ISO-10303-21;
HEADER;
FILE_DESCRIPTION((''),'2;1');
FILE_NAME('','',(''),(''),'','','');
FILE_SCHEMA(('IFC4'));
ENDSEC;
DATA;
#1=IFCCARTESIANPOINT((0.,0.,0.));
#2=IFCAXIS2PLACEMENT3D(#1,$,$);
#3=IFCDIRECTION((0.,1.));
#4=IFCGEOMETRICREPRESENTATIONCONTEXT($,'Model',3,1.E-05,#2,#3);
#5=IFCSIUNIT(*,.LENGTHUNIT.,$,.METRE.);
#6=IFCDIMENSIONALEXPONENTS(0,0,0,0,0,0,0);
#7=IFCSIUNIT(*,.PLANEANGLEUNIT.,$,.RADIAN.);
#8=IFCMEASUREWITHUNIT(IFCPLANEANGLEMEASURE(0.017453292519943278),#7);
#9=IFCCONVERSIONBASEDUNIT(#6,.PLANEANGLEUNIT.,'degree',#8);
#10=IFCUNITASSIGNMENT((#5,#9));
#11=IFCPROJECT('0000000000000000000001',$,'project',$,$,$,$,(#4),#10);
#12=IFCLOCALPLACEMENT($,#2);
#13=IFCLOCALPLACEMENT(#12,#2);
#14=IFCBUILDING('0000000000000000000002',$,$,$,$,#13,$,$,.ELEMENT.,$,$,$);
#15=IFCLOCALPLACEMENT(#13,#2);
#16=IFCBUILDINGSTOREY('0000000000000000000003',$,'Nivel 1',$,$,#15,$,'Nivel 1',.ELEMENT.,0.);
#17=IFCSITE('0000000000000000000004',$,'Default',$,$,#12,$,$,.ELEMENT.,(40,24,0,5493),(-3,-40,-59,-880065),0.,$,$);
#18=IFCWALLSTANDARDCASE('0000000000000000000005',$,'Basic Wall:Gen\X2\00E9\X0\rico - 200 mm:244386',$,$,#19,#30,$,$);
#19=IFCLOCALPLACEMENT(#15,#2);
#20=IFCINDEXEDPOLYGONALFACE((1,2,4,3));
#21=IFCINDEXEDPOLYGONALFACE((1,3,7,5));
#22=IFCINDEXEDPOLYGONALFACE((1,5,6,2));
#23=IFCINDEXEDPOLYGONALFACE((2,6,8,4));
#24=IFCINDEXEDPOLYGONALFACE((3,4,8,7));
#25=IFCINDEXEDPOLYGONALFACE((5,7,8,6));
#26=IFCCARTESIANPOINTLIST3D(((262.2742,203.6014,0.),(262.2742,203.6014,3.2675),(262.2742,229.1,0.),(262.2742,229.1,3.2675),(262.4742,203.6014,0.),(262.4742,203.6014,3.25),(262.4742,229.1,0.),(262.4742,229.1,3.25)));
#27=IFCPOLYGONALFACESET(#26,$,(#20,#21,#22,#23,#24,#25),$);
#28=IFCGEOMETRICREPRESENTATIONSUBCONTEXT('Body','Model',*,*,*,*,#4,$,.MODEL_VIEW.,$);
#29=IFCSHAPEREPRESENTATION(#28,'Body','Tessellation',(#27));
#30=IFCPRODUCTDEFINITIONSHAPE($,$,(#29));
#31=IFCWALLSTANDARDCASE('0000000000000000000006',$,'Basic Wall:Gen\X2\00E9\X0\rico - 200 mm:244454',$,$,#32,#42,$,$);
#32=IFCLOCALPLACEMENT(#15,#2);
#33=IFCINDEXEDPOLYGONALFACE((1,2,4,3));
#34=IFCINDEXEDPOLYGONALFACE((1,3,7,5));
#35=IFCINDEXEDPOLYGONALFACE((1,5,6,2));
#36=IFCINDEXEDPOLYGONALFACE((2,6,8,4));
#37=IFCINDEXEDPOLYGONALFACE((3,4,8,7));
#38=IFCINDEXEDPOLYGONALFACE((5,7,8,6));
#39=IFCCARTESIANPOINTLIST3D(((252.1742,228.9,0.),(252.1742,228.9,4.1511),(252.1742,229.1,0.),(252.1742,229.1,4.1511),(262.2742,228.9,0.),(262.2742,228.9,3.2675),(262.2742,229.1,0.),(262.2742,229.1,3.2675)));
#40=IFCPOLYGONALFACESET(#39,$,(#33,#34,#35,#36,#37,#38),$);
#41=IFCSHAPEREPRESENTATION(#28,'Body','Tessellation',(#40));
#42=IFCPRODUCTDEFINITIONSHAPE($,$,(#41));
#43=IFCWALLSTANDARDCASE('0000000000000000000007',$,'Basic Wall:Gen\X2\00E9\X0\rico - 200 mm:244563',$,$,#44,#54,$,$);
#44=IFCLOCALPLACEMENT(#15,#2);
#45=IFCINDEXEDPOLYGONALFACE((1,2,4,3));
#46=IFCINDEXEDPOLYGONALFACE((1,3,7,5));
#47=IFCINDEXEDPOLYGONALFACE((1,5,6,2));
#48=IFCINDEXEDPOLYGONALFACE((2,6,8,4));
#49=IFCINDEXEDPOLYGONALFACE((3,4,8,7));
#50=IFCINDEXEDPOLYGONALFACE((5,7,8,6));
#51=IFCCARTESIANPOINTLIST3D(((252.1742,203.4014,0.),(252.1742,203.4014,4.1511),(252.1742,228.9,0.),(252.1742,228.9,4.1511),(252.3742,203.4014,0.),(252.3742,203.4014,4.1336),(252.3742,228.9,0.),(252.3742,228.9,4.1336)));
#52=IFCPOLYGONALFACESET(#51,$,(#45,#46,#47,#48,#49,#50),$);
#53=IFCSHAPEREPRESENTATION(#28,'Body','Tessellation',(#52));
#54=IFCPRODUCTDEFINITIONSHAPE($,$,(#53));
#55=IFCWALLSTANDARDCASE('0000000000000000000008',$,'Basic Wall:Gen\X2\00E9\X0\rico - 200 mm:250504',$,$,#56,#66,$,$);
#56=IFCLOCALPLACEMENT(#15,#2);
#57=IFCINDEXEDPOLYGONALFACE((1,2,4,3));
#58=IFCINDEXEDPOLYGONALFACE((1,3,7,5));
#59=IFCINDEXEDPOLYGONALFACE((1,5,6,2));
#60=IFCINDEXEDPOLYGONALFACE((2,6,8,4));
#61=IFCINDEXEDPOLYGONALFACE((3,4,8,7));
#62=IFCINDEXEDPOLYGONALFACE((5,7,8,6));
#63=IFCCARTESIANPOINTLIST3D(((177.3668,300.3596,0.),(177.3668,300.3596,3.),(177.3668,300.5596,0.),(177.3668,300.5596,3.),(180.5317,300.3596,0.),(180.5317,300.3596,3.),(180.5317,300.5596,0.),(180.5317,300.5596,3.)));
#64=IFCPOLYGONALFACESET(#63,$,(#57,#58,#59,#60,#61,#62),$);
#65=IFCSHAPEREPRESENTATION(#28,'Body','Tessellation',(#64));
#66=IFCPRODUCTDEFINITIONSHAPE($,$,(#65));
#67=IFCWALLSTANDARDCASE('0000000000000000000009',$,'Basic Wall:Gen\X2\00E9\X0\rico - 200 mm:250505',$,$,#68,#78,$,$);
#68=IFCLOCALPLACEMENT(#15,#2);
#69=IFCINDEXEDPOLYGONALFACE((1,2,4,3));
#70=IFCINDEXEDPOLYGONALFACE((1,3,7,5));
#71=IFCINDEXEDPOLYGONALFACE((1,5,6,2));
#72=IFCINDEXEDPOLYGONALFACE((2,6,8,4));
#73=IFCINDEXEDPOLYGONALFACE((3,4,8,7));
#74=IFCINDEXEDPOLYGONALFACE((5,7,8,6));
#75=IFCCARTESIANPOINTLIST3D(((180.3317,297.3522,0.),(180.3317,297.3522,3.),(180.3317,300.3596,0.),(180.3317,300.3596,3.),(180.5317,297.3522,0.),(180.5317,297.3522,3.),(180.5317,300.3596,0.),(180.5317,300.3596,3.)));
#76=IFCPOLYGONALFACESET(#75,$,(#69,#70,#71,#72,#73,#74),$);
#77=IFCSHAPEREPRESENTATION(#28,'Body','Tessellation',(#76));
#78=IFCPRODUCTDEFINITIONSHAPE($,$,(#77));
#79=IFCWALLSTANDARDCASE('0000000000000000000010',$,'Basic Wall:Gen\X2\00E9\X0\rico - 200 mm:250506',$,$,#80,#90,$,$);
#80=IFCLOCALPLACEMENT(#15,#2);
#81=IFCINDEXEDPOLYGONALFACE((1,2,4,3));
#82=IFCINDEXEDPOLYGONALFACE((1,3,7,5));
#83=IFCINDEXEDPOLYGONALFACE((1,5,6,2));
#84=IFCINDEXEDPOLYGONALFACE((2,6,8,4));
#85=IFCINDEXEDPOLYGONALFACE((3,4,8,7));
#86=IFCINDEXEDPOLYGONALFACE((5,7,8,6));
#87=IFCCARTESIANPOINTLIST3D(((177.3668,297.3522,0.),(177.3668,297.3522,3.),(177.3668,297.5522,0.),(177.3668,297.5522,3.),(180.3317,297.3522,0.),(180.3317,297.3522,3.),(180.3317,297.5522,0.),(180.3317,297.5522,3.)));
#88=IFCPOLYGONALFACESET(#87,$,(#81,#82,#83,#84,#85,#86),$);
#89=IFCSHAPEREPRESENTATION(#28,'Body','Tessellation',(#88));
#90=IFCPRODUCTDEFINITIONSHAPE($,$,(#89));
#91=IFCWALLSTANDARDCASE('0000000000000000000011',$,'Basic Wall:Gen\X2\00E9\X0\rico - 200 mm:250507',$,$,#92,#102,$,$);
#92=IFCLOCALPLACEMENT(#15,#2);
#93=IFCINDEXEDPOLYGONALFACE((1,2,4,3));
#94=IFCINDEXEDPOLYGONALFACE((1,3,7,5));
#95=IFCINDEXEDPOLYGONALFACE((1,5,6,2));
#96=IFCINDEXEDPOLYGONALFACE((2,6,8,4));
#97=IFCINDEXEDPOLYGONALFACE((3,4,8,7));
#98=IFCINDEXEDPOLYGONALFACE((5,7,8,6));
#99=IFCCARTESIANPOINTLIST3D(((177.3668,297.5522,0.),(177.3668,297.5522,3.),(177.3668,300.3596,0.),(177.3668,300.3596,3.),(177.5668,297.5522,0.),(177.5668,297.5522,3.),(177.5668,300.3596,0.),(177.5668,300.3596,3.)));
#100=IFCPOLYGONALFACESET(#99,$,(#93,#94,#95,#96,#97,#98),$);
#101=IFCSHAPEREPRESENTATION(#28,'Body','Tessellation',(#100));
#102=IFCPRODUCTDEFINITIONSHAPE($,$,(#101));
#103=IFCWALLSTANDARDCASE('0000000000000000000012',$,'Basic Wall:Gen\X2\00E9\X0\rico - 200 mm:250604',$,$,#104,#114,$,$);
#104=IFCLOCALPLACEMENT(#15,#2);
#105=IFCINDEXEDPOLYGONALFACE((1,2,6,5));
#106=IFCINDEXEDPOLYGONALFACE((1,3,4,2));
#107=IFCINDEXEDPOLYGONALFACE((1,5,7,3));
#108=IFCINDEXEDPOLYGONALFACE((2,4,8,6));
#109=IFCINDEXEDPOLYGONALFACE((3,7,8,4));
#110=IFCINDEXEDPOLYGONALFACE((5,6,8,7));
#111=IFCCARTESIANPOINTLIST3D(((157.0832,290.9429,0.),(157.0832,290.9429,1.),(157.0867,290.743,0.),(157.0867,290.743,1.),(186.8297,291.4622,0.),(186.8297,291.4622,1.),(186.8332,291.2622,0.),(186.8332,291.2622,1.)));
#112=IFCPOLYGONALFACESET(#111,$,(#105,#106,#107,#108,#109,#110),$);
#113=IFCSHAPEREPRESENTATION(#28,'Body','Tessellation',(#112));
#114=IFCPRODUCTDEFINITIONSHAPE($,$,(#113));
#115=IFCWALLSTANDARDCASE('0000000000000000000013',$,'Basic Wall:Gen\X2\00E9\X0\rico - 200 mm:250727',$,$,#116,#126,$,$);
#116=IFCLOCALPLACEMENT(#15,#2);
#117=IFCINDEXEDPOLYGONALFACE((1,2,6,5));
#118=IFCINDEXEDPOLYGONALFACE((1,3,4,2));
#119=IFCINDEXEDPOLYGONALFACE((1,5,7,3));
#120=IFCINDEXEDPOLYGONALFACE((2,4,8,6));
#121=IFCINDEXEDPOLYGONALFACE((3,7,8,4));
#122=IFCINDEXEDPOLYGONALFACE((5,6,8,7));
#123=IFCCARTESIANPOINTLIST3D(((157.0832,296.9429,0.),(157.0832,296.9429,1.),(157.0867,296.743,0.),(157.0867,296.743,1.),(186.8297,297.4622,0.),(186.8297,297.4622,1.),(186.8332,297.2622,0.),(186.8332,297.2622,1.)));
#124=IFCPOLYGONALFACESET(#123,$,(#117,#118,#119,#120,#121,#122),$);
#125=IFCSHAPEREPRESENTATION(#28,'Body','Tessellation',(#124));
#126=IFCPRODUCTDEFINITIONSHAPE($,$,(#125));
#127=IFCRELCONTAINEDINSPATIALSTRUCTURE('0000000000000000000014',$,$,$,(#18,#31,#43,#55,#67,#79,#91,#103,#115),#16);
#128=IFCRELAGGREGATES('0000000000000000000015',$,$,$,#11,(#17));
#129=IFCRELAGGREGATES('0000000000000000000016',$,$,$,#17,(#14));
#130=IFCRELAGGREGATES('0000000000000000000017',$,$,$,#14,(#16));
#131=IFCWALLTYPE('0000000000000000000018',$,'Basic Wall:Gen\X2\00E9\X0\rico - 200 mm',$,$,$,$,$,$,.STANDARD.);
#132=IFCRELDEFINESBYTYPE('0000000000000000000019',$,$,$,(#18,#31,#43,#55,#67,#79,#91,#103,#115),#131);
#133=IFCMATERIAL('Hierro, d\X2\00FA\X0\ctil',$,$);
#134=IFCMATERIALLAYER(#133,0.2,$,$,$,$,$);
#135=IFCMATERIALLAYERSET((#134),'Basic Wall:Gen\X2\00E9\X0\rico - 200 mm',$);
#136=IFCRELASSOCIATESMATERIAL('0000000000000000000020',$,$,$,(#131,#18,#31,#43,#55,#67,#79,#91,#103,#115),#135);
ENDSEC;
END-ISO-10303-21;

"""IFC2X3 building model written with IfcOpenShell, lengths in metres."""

from ifc_helpers import new_model, entity, si_unit, converted_unit, direction, frame, frame_2d, origin, place, context, subcontext, project, spatial, polyline, rectangle, extrude, clip, bounded_halfspace, material, layer, layer_set, layer_usage, type_object, element, save


model = new_model("IFC2X3")

# Units and contexts
model_context = context("Model", 3, precision=1e-05, world=origin(), true_north=direction((0.0, 1.0)))
body_context = subcontext(model_context, "Body", "Model", "MODEL_VIEW")
ifc_project = project(units=[si_unit("LENGTHUNIT", "METRE"), converted_unit("PLANEANGLEUNIT", "degree", entity("IfcPlaneAngleMeasure", 0.017453292519943278), si_unit("PLANEANGLEUNIT", "RADIAN"), dimensions=[0, 0, 0, 0, 0, 0, 0])], contexts=[model_context])

# Site, building, storey
site_placement = place(None, origin())
site = spatial("IfcSite", under=ifc_project, at=site_placement, Name="Default", CompositionType="ELEMENT", RefLatitude=(40, 24, 0, 5493), RefLongitude=(-3, -40, -59, -880065), RefElevation=0.0)
building_placement = place(site_placement, origin())
building = spatial("IfcBuilding", under=site, at=building_placement, CompositionType="ELEMENT")
storey_placement = place(building_placement, origin())
storey = spatial("IfcBuildingStorey", under=building, at=storey_placement, Name="Nivel 1", LongName="Nivel 1", CompositionType="ELEMENT", Elevation=0.0)

# Walls
ifc_material_1 = material(Name="Hierro, dúctil")
ifc_layer_1 = layer(ifc_material_1, 0.2)
ifc_layer_set_1 = layer_set([ifc_layer_1], Name="Basic Wall:Genérico - 200 mm")
wall_type = type_object("IfcWallType", Name="Basic Wall:Genérico - 200 mm", PredefinedType="STANDARD", material=ifc_layer_set_1)
ifc_layer_usage_1 = layer_usage(ifc_layer_set_1, "AXIS2", "NEGATIVE", 0.1)
wall_1_placement = place(storey_placement, frame((262.3742, 203.6014, 0.0), z_axis=(0.0, 0.0, 1.0), x_axis=(0.0, 1.0, 0.0)))
element("IfcWallStandardCase", 1, at=wall_1_placement, inside=storey, type_object=wall_type, material=ifc_layer_usage_1, Name="Basic Wall:Genérico - 200 mm:244386", context=body_context, shape_type="Clipping", body=[
    clip(extrude(rectangle(XDim=25.4986, YDim=0.2, at=frame_2d((12.7493, 0.0), x_axis=(-1.0, 0.0))), origin(), (0.0, 0.0, 1.0), 3.2675), bounded_halfspace(frame((0.0, -0.1, 3.25), z_axis=(0.0, -0.087156, 0.996195), x_axis=(1.0, 0.0, 0.0)), False, frame((0.0, -0.1, 3.25)), polyline([(0.0, 0.0), (25.4986, 0.0), (25.4986, 0.2), (25.2986, 0.2), (0.0, 0.2), (0.0, 0.0)]))),
])
ifc_layer_usage_2 = layer_usage(ifc_layer_set_1, "AXIS2", "NEGATIVE", 0.1)
wall_2_placement = place(storey_placement, frame((262.2742, 229.0, 0.0), z_axis=(0.0, 0.0, 1.0), x_axis=(-1.0, 0.0, 0.0)))
element("IfcWallStandardCase", 2, at=wall_2_placement, inside=storey, type_object=wall_type, material=ifc_layer_usage_2, Name="Basic Wall:Genérico - 200 mm:244454", context=body_context, shape_type="Clipping", body=[
    clip(extrude(rectangle(XDim=10.1, YDim=0.2, at=frame_2d((5.05, 0.0), x_axis=(-1.0, 0.0))), origin(), (0.0, 0.0, 1.0), 4.1511), bounded_halfspace(frame((0.0, -0.1, 3.2675), z_axis=(-0.087156, 0.0, 0.996195), x_axis=(0.0, -1.0, 0.0)), False, frame((0.0, -0.1, 3.2675)), polyline([(0.0, 0.0), (10.1, 0.0), (10.1, 0.2), (9.9, 0.2), (0.0, 0.2), (0.0, 0.0)]))),
])
ifc_layer_usage_3 = layer_usage(ifc_layer_set_1, "AXIS2", "NEGATIVE", 0.1)
wall_3_placement = place(storey_placement, frame((252.2742, 228.9, 0.0), z_axis=(0.0, 0.0, 1.0), x_axis=(0.0, -1.0, 0.0)))
element("IfcWallStandardCase", 3, at=wall_3_placement, inside=storey, type_object=wall_type, material=ifc_layer_usage_3, Name="Basic Wall:Genérico - 200 mm:244563", context=body_context, shape_type="Clipping", body=[
    clip(extrude(rectangle(XDim=25.4986, YDim=0.2, at=frame_2d((12.7493, 0.0), x_axis=(-1.0, 0.0))), origin(), (0.0, 0.0, 1.0), 4.1511), bounded_halfspace(frame((0.0, -0.1, 4.1511), z_axis=(0.0, 0.087156, 0.996195), x_axis=(-1.0, 0.0, 0.0)), False, frame((0.0, -0.1, 4.1511)), polyline([(0.0, 0.0), (25.4986, 0.0), (25.4986, 0.2), (25.2986, 0.2), (0.0, 0.2), (0.0, 0.0)]))),
])
ifc_layer_usage_4 = layer_usage(ifc_layer_set_1, "AXIS2", "NEGATIVE", 0.1)
wall_4_placement = place(storey_placement, frame((177.3668, 300.4596, 0.0)))
element("IfcWallStandardCase", 4, at=wall_4_placement, inside=storey, type_object=wall_type, material=ifc_layer_usage_4, Name="Basic Wall:Genérico - 200 mm:250504", context=body_context, shape_type="SweptSolid", body=[
    extrude(rectangle(XDim=3.165, YDim=0.2, at=frame_2d((1.5825, 0.0), x_axis=(-1.0, 0.0))), origin(), (0.0, 0.0, 1.0), 3.0),
])
ifc_layer_usage_5 = layer_usage(ifc_layer_set_1, "AXIS2", "NEGATIVE", 0.1)
wall_5_placement = place(storey_placement, frame((180.4317, 300.3596, 0.0), z_axis=(0.0, 0.0, 1.0), x_axis=(0.0, -1.0, 0.0)))
element("IfcWallStandardCase", 5, at=wall_5_placement, inside=storey, type_object=wall_type, material=ifc_layer_usage_5, Name="Basic Wall:Genérico - 200 mm:250505", context=body_context, shape_type="SweptSolid", body=[
    extrude(rectangle(XDim=3.0073, YDim=0.2, at=frame_2d((1.5037, 0.0), x_axis=(-1.0, 0.0))), origin(), (0.0, 0.0, 1.0), 3.0),
])
ifc_layer_usage_6 = layer_usage(ifc_layer_set_1, "AXIS2", "NEGATIVE", 0.1)
wall_6_placement = place(storey_placement, frame((180.3317, 297.4522, 0.0), z_axis=(0.0, 0.0, 1.0), x_axis=(-1.0, 0.0, 0.0)))
element("IfcWallStandardCase", 6, at=wall_6_placement, inside=storey, type_object=wall_type, material=ifc_layer_usage_6, Name="Basic Wall:Genérico - 200 mm:250506", context=body_context, shape_type="SweptSolid", body=[
    extrude(rectangle(XDim=2.965, YDim=0.2, at=frame_2d((1.4825, 0.0), x_axis=(-1.0, 0.0))), origin(), (0.0, 0.0, 1.0), 3.0),
])
ifc_layer_usage_7 = layer_usage(ifc_layer_set_1, "AXIS2", "NEGATIVE", 0.1)
wall_7_placement = place(storey_placement, frame((177.4668, 297.5522, 0.0), z_axis=(0.0, 0.0, 1.0), x_axis=(0.0, 1.0, 0.0)))
element("IfcWallStandardCase", 7, at=wall_7_placement, inside=storey, type_object=wall_type, material=ifc_layer_usage_7, Name="Basic Wall:Genérico - 200 mm:250507", context=body_context, shape_type="SweptSolid", body=[
    extrude(rectangle(XDim=2.8073, YDim=0.2, at=frame_2d((1.4037, 0.0), x_axis=(-1.0, 0.0))), origin(), (0.0, 0.0, 1.0), 3.0),
])
ifc_layer_usage_8 = layer_usage(ifc_layer_set_1, "AXIS2", "NEGATIVE", 0.1)
wall_8_placement = place(storey_placement, frame((186.8314, 291.3622, 0.0), z_axis=(0.0, 0.0, 1.0), x_axis=(-0.999848, -0.017452, 0.0)))
element("IfcWallStandardCase", 8, at=wall_8_placement, inside=storey, type_object=wall_type, material=ifc_layer_usage_8, Name="Basic Wall:Genérico - 200 mm:250604", context=body_context, shape_type="SweptSolid", body=[
    extrude(rectangle(XDim=29.751, YDim=0.2, at=frame_2d((14.8755, 0.0), x_axis=(-1.0, 0.0))), origin(), (0.0, 0.0, 1.0), 1.0),
])
ifc_layer_usage_9 = layer_usage(ifc_layer_set_1, "AXIS2", "NEGATIVE", 0.1)
wall_9_placement = place(storey_placement, frame((186.8314, 297.3622, 0.0), z_axis=(0.0, 0.0, 1.0), x_axis=(-0.999848, -0.017452, 0.0)))
element("IfcWallStandardCase", 9, at=wall_9_placement, inside=storey, type_object=wall_type, material=ifc_layer_usage_9, Name="Basic Wall:Genérico - 200 mm:250727", context=body_context, shape_type="SweptSolid", body=[
    extrude(rectangle(XDim=29.751, YDim=0.2, at=frame_2d((14.8755, 0.0), x_axis=(-1.0, 0.0))), origin(), (0.0, 0.0, 1.0), 1.0),
])

save(model, "model.ifc")
